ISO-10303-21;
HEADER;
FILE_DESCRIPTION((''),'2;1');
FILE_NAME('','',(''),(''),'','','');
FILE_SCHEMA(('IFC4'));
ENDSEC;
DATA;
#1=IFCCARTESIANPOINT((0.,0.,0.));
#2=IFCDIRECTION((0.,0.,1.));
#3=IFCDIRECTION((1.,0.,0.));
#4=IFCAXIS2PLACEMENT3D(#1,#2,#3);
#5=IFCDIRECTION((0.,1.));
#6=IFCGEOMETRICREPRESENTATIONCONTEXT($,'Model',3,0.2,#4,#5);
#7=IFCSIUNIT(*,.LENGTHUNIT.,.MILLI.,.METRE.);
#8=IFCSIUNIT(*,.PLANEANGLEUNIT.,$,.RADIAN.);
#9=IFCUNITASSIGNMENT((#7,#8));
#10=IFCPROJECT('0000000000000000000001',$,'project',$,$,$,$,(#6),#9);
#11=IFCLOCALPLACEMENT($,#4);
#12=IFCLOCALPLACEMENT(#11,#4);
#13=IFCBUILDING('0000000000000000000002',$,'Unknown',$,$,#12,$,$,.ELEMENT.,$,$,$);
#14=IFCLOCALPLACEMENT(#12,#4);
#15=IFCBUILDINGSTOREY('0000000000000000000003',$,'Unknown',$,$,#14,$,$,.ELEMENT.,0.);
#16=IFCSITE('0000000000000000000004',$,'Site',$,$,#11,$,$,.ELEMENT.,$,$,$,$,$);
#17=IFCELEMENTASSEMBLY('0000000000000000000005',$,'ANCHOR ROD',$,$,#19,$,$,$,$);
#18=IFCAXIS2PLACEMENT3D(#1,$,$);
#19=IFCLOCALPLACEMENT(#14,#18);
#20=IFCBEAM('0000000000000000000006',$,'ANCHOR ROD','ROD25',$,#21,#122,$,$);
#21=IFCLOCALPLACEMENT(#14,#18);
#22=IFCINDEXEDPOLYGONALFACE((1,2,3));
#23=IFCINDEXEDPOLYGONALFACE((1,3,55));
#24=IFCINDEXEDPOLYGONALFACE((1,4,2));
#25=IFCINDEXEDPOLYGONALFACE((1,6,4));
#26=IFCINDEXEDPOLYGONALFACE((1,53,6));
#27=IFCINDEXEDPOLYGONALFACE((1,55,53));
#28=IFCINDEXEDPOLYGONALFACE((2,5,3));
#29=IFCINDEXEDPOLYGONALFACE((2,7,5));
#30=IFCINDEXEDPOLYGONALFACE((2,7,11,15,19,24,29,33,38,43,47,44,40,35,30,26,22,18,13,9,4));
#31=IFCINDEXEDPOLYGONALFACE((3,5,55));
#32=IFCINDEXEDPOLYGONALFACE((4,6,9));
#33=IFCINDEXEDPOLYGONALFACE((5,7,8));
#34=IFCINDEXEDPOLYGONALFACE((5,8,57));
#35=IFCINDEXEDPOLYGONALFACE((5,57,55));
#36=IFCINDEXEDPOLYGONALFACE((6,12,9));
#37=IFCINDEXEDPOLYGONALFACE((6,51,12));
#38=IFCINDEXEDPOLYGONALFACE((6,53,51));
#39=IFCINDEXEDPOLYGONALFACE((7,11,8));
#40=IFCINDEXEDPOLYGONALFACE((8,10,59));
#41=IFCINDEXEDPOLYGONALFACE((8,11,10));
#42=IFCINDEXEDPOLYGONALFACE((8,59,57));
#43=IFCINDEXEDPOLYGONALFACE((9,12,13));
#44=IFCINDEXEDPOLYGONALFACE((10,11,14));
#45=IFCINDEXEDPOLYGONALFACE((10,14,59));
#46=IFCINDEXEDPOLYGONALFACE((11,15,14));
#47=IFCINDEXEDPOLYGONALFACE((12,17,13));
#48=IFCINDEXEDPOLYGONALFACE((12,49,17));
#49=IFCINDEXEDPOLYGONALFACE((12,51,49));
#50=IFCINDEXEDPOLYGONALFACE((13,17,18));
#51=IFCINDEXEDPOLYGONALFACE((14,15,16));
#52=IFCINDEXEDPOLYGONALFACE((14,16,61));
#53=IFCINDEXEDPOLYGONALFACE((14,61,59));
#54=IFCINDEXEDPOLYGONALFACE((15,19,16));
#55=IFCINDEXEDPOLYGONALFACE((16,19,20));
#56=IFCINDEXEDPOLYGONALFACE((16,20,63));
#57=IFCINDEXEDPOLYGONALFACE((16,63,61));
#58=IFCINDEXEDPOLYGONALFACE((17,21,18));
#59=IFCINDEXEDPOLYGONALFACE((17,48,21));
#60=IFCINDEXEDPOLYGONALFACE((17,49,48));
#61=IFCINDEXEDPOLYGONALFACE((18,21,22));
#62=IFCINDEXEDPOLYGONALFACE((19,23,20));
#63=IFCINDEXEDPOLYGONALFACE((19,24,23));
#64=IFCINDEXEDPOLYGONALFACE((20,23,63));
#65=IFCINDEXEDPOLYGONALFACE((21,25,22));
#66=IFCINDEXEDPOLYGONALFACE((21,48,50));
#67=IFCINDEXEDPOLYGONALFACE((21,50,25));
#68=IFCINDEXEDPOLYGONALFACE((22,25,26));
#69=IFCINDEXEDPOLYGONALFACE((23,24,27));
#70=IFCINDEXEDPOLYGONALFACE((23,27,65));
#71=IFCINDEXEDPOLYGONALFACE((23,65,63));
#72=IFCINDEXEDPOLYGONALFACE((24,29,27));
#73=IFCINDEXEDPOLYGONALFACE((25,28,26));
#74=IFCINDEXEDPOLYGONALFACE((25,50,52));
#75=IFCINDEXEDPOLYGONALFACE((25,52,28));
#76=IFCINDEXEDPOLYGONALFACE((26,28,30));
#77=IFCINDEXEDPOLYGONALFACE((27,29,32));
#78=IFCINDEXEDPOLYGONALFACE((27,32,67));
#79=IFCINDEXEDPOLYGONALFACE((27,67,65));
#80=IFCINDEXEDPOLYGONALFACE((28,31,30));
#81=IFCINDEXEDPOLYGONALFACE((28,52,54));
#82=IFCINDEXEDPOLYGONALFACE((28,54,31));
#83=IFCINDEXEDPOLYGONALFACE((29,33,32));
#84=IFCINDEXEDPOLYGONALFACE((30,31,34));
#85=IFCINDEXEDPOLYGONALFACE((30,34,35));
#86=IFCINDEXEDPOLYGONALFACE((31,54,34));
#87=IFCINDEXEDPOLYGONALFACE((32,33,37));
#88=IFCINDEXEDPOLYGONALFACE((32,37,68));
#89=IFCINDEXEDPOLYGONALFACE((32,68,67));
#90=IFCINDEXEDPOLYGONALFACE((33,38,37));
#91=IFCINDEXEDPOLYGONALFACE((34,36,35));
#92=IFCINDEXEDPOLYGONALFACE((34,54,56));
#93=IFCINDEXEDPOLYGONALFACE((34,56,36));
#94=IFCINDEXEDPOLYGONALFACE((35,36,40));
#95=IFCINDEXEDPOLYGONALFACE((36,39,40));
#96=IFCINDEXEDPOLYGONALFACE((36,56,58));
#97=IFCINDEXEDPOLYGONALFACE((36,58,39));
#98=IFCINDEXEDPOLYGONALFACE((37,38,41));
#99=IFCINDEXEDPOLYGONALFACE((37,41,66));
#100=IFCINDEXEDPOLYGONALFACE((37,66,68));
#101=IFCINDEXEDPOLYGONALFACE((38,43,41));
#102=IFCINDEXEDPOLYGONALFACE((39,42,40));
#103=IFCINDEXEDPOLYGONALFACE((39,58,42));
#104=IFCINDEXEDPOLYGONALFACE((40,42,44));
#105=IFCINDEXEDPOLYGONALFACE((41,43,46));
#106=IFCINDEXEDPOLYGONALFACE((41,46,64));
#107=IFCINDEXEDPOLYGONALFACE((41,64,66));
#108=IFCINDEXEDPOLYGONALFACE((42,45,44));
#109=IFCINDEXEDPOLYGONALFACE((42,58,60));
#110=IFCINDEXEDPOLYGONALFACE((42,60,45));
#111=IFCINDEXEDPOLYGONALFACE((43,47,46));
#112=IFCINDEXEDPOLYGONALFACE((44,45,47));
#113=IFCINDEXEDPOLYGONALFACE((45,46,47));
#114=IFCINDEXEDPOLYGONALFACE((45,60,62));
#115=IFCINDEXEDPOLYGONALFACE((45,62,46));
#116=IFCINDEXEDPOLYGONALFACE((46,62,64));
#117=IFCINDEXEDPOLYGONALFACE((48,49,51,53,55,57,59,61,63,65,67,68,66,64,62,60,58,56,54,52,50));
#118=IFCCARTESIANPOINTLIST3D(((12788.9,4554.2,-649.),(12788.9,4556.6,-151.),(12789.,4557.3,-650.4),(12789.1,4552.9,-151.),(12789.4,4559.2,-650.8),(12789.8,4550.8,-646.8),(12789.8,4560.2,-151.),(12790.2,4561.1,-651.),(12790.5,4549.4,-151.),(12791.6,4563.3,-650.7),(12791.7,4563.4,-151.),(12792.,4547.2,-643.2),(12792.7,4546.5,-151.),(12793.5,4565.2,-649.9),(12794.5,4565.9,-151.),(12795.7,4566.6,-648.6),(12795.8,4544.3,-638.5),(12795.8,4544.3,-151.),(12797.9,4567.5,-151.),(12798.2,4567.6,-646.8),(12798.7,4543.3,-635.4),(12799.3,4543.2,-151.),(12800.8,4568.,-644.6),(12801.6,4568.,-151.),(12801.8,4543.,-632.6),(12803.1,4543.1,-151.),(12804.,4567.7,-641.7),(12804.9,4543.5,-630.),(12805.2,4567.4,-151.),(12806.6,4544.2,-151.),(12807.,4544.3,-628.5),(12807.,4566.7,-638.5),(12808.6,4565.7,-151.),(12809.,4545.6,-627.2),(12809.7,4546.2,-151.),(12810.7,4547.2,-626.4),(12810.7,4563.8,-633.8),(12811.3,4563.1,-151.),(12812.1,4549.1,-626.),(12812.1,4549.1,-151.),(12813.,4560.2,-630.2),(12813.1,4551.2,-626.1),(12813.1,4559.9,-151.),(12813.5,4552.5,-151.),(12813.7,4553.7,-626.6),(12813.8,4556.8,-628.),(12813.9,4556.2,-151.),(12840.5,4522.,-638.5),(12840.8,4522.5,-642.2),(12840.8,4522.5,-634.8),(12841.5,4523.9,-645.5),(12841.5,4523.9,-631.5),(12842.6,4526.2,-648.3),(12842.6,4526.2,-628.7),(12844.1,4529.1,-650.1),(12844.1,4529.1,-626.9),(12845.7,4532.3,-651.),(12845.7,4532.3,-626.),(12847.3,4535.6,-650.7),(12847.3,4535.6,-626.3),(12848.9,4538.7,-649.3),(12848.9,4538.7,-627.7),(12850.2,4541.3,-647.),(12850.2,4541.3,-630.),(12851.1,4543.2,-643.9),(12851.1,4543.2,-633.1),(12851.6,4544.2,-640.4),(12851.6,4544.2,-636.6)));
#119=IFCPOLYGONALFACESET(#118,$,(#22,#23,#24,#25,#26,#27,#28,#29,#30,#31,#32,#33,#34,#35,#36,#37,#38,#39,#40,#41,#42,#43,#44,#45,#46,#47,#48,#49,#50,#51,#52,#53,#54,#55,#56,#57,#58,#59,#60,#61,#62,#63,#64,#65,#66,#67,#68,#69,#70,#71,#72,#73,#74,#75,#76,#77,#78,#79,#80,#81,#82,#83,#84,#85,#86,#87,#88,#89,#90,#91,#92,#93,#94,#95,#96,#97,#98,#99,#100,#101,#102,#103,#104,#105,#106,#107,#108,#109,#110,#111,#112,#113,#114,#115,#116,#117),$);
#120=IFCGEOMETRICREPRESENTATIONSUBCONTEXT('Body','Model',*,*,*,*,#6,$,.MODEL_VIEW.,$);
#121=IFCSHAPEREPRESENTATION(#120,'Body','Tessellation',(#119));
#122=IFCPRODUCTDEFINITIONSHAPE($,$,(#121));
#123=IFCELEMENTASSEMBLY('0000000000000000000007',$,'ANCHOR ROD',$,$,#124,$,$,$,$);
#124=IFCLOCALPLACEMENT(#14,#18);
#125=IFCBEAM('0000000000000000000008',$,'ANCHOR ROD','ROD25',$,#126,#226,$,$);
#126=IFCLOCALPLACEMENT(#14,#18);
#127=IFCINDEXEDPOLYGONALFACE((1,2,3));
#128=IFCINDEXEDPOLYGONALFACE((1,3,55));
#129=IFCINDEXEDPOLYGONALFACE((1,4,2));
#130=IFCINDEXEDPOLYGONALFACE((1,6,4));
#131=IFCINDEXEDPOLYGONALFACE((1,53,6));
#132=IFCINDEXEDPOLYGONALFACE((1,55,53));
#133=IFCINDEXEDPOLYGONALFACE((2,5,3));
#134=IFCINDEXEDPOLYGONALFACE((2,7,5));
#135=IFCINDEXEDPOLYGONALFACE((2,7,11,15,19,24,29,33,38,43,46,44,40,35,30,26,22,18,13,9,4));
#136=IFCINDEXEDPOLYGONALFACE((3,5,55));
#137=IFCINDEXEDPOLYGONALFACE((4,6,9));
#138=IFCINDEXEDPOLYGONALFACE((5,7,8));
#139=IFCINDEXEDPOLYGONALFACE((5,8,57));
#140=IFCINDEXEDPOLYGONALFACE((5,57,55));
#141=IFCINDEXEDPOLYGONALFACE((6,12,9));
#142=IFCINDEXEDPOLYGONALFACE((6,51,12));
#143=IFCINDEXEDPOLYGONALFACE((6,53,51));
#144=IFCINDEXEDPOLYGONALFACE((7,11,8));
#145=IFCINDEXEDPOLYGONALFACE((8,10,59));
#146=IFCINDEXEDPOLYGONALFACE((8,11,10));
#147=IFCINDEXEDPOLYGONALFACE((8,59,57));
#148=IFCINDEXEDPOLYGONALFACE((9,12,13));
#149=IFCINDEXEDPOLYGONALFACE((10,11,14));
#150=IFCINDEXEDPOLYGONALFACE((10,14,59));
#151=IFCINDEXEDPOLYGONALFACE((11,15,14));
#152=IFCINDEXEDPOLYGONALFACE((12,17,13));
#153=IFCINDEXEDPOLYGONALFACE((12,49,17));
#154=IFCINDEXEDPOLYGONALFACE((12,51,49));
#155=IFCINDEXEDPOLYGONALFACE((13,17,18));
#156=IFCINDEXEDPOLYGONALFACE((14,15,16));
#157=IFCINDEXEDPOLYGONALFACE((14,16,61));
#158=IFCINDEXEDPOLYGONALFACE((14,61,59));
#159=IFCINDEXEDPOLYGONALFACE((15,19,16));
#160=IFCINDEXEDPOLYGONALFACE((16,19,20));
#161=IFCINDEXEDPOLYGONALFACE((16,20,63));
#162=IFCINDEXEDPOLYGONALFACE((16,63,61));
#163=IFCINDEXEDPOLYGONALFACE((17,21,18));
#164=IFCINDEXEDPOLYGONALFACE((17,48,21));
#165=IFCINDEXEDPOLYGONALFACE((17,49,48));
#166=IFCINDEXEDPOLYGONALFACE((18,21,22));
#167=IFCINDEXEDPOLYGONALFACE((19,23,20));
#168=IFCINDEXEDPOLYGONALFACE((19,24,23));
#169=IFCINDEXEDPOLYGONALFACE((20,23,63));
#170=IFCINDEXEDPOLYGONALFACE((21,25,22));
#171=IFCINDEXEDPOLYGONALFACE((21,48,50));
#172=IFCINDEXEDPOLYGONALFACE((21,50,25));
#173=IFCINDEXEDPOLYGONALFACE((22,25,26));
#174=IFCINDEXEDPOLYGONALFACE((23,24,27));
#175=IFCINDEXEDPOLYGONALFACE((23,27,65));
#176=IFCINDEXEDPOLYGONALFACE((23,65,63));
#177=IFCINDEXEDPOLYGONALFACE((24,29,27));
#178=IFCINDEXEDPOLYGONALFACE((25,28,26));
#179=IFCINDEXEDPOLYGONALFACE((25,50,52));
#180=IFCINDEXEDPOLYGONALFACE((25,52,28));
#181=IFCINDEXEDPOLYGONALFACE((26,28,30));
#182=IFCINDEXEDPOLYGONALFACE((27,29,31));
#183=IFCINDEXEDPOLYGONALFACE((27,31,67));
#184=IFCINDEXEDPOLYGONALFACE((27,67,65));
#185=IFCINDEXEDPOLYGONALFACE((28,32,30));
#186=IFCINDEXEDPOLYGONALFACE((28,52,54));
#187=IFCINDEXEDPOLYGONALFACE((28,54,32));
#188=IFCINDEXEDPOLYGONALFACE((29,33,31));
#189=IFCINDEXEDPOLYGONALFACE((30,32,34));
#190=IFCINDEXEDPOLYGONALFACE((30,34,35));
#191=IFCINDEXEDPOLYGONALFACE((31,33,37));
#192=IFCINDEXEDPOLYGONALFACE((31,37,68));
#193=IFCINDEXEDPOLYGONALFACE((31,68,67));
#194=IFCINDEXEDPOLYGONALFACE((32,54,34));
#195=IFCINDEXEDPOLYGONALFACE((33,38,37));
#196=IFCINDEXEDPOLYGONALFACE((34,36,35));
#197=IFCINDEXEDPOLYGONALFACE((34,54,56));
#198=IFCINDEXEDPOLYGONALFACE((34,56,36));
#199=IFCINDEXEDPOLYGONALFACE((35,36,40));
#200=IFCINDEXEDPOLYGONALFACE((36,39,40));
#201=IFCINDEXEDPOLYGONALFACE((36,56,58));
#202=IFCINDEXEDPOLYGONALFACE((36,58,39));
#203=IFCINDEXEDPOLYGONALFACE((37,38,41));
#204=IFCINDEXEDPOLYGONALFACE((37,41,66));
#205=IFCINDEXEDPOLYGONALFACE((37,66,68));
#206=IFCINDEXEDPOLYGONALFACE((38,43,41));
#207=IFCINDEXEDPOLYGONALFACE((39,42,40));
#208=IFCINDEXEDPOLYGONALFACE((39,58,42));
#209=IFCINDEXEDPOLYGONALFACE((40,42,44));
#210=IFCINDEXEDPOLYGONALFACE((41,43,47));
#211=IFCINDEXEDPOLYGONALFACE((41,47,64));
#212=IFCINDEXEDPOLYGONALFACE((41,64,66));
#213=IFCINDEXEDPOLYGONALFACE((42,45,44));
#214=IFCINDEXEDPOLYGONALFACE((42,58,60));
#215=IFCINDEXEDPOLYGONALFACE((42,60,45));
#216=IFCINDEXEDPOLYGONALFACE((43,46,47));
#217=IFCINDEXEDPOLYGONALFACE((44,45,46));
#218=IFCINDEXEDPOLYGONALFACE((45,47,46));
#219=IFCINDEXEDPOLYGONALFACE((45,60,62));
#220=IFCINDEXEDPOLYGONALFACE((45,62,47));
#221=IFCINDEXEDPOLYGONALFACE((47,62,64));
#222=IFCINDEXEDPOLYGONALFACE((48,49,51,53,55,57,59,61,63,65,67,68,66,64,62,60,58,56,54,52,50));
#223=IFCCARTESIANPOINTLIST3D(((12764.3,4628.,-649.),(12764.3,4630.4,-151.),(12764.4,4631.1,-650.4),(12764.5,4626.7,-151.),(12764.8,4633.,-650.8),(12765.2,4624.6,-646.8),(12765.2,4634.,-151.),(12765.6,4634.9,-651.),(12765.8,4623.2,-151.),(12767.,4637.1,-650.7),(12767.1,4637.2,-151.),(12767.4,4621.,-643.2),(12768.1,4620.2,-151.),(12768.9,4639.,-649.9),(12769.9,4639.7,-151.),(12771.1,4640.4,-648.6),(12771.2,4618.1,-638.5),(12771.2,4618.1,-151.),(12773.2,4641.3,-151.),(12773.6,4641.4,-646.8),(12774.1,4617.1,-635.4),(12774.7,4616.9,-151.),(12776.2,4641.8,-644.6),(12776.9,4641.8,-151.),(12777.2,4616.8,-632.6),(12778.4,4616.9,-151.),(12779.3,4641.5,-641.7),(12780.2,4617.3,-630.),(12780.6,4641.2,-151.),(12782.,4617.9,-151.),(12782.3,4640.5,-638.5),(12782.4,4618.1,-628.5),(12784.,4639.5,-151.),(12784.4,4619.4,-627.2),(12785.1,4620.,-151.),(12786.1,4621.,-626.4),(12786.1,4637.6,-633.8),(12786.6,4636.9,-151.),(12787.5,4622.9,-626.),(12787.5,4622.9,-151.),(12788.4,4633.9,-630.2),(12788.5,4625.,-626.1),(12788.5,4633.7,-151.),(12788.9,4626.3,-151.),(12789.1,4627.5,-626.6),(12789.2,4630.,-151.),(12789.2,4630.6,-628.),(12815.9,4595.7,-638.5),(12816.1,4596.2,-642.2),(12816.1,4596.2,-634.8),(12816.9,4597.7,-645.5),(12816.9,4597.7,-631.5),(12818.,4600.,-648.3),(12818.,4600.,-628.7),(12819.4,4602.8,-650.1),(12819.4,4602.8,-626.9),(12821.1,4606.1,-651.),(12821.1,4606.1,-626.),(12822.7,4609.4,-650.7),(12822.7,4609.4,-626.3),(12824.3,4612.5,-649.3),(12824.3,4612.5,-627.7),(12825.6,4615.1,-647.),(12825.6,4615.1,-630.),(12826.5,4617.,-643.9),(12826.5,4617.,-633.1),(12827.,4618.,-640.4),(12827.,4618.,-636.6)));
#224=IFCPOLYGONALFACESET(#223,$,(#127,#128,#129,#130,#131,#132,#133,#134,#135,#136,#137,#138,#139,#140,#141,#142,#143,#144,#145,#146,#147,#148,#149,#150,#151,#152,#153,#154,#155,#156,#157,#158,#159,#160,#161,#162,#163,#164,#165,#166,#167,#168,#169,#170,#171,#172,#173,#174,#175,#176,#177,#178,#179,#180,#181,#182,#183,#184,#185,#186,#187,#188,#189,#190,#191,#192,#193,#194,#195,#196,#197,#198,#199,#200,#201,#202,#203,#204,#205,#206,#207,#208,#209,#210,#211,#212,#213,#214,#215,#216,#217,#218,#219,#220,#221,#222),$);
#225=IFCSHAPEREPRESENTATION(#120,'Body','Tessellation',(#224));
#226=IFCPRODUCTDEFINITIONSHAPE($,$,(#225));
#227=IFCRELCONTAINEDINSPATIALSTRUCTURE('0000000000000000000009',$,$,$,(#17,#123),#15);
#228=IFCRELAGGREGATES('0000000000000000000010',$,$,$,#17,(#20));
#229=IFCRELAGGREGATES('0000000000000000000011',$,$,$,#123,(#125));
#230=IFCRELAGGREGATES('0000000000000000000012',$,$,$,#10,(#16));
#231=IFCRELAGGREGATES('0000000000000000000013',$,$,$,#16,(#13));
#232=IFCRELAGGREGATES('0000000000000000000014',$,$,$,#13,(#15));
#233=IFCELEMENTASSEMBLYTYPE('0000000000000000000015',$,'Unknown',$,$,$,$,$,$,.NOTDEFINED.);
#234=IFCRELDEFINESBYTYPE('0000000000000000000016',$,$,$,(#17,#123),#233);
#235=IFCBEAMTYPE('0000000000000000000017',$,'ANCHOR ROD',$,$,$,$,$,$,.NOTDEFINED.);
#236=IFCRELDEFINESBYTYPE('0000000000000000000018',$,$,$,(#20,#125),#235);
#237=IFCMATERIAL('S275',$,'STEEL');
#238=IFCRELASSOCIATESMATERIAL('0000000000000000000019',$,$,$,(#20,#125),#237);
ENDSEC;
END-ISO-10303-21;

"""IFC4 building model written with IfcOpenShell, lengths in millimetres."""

from ifc_helpers import new_model, entity, si_unit, direction, frame, origin_with_axes, place, context, subcontext, project, spatial, material, type_object, element, aggregate, save


model = new_model("IFC4")

# Units and contexts
model_context = context("Model", 3, precision=0.2, world=origin_with_axes(), true_north=direction((0.0, 1.0)))
body_context = subcontext(model_context, "Body", "Model", "MODEL_VIEW")
ifc_project = project(units=[si_unit("LENGTHUNIT", "METRE", prefix="MILLI"), si_unit("PLANEANGLEUNIT", "RADIAN")], contexts=[model_context])

# Site, building, storey
site_placement = place(None, origin_with_axes())
site = spatial("IfcSite", under=ifc_project, at=site_placement, Name="Site", CompositionType="ELEMENT")
building_placement = place(site_placement, origin_with_axes())
building = spatial("IfcBuilding", under=site, at=building_placement, Name="Unknown", CompositionType="ELEMENT")
storey_placement = place(building_placement, origin_with_axes())
storey = spatial("IfcBuildingStorey", under=building, at=storey_placement, Name="Unknown", CompositionType="ELEMENT", Elevation=0.0)

# Element assemblies, beams
element_assembly_type = type_object("IfcElementAssemblyType", Name="Unknown", PredefinedType="NOTDEFINED")
ifc_material_1 = material(Name="S275", Category="STEEL")
beam_type_1 = type_object("IfcBeamType", Name="ANCHOR ROD", PredefinedType="NOTDEFINED")
assembly_1_placement = place(storey_placement, frame((12801.4, 4555.5, -151.0), z_axis=(-0.447007, -0.894531, 0.0), x_axis=(0.0, 0.0, -1.0)))
assembly_1 = element("IfcElementAssembly", 1, at=assembly_1_placement, inside=storey, type_object=element_assembly_type, Name="ANCHOR ROD")
beam_1_placement = place(assembly_1_placement, origin_with_axes())
beam_1 = element("IfcBeam", 2, at=beam_1_placement, type_object=beam_type_1, material=ifc_material_1, Name="ANCHOR ROD", Description="ROD25", context=body_context, shape_type="SolidModel", body=[
    entity("IfcSweptDiskSolid", entity("IfcIndexedPolyCurve", entity("IfcCartesianPointList3D", [[0.0, 0.0, 0.0], [487.5, 0.0, 0.0], [487.5, 50.0, 0.0]]), [entity("IfcLineIndex", [1, 2, 3])]), 12.5),
])
aggregate(assembly_1, [beam_1])
assembly_2_placement = place(storey_placement, frame((12776.8, 4629.3, -151.0), z_axis=(-0.447007, -0.894531, 0.0), x_axis=(0.0, 0.0, -1.0)))
assembly_2 = element("IfcElementAssembly", 3, at=assembly_2_placement, inside=storey, type_object=element_assembly_type, Name="ANCHOR ROD")
beam_2_placement = place(assembly_2_placement, origin_with_axes())
beam_2 = element("IfcBeam", 4, at=beam_2_placement, type_object=beam_type_1, material=ifc_material_1, Name="ANCHOR ROD", Description="ROD25", context=body_context, shape_type="SolidModel", body=[
    entity("IfcSweptDiskSolid", entity("IfcIndexedPolyCurve", entity("IfcCartesianPointList3D", [[0.0, 0.0, 0.0], [487.5, 0.0, 0.0], [487.5, 50.0, 0.0]]), [entity("IfcLineIndex", [1, 2, 3])]), 12.5),
])

aggregate(assembly_2, [beam_2])

save(model, "model.ifc")
